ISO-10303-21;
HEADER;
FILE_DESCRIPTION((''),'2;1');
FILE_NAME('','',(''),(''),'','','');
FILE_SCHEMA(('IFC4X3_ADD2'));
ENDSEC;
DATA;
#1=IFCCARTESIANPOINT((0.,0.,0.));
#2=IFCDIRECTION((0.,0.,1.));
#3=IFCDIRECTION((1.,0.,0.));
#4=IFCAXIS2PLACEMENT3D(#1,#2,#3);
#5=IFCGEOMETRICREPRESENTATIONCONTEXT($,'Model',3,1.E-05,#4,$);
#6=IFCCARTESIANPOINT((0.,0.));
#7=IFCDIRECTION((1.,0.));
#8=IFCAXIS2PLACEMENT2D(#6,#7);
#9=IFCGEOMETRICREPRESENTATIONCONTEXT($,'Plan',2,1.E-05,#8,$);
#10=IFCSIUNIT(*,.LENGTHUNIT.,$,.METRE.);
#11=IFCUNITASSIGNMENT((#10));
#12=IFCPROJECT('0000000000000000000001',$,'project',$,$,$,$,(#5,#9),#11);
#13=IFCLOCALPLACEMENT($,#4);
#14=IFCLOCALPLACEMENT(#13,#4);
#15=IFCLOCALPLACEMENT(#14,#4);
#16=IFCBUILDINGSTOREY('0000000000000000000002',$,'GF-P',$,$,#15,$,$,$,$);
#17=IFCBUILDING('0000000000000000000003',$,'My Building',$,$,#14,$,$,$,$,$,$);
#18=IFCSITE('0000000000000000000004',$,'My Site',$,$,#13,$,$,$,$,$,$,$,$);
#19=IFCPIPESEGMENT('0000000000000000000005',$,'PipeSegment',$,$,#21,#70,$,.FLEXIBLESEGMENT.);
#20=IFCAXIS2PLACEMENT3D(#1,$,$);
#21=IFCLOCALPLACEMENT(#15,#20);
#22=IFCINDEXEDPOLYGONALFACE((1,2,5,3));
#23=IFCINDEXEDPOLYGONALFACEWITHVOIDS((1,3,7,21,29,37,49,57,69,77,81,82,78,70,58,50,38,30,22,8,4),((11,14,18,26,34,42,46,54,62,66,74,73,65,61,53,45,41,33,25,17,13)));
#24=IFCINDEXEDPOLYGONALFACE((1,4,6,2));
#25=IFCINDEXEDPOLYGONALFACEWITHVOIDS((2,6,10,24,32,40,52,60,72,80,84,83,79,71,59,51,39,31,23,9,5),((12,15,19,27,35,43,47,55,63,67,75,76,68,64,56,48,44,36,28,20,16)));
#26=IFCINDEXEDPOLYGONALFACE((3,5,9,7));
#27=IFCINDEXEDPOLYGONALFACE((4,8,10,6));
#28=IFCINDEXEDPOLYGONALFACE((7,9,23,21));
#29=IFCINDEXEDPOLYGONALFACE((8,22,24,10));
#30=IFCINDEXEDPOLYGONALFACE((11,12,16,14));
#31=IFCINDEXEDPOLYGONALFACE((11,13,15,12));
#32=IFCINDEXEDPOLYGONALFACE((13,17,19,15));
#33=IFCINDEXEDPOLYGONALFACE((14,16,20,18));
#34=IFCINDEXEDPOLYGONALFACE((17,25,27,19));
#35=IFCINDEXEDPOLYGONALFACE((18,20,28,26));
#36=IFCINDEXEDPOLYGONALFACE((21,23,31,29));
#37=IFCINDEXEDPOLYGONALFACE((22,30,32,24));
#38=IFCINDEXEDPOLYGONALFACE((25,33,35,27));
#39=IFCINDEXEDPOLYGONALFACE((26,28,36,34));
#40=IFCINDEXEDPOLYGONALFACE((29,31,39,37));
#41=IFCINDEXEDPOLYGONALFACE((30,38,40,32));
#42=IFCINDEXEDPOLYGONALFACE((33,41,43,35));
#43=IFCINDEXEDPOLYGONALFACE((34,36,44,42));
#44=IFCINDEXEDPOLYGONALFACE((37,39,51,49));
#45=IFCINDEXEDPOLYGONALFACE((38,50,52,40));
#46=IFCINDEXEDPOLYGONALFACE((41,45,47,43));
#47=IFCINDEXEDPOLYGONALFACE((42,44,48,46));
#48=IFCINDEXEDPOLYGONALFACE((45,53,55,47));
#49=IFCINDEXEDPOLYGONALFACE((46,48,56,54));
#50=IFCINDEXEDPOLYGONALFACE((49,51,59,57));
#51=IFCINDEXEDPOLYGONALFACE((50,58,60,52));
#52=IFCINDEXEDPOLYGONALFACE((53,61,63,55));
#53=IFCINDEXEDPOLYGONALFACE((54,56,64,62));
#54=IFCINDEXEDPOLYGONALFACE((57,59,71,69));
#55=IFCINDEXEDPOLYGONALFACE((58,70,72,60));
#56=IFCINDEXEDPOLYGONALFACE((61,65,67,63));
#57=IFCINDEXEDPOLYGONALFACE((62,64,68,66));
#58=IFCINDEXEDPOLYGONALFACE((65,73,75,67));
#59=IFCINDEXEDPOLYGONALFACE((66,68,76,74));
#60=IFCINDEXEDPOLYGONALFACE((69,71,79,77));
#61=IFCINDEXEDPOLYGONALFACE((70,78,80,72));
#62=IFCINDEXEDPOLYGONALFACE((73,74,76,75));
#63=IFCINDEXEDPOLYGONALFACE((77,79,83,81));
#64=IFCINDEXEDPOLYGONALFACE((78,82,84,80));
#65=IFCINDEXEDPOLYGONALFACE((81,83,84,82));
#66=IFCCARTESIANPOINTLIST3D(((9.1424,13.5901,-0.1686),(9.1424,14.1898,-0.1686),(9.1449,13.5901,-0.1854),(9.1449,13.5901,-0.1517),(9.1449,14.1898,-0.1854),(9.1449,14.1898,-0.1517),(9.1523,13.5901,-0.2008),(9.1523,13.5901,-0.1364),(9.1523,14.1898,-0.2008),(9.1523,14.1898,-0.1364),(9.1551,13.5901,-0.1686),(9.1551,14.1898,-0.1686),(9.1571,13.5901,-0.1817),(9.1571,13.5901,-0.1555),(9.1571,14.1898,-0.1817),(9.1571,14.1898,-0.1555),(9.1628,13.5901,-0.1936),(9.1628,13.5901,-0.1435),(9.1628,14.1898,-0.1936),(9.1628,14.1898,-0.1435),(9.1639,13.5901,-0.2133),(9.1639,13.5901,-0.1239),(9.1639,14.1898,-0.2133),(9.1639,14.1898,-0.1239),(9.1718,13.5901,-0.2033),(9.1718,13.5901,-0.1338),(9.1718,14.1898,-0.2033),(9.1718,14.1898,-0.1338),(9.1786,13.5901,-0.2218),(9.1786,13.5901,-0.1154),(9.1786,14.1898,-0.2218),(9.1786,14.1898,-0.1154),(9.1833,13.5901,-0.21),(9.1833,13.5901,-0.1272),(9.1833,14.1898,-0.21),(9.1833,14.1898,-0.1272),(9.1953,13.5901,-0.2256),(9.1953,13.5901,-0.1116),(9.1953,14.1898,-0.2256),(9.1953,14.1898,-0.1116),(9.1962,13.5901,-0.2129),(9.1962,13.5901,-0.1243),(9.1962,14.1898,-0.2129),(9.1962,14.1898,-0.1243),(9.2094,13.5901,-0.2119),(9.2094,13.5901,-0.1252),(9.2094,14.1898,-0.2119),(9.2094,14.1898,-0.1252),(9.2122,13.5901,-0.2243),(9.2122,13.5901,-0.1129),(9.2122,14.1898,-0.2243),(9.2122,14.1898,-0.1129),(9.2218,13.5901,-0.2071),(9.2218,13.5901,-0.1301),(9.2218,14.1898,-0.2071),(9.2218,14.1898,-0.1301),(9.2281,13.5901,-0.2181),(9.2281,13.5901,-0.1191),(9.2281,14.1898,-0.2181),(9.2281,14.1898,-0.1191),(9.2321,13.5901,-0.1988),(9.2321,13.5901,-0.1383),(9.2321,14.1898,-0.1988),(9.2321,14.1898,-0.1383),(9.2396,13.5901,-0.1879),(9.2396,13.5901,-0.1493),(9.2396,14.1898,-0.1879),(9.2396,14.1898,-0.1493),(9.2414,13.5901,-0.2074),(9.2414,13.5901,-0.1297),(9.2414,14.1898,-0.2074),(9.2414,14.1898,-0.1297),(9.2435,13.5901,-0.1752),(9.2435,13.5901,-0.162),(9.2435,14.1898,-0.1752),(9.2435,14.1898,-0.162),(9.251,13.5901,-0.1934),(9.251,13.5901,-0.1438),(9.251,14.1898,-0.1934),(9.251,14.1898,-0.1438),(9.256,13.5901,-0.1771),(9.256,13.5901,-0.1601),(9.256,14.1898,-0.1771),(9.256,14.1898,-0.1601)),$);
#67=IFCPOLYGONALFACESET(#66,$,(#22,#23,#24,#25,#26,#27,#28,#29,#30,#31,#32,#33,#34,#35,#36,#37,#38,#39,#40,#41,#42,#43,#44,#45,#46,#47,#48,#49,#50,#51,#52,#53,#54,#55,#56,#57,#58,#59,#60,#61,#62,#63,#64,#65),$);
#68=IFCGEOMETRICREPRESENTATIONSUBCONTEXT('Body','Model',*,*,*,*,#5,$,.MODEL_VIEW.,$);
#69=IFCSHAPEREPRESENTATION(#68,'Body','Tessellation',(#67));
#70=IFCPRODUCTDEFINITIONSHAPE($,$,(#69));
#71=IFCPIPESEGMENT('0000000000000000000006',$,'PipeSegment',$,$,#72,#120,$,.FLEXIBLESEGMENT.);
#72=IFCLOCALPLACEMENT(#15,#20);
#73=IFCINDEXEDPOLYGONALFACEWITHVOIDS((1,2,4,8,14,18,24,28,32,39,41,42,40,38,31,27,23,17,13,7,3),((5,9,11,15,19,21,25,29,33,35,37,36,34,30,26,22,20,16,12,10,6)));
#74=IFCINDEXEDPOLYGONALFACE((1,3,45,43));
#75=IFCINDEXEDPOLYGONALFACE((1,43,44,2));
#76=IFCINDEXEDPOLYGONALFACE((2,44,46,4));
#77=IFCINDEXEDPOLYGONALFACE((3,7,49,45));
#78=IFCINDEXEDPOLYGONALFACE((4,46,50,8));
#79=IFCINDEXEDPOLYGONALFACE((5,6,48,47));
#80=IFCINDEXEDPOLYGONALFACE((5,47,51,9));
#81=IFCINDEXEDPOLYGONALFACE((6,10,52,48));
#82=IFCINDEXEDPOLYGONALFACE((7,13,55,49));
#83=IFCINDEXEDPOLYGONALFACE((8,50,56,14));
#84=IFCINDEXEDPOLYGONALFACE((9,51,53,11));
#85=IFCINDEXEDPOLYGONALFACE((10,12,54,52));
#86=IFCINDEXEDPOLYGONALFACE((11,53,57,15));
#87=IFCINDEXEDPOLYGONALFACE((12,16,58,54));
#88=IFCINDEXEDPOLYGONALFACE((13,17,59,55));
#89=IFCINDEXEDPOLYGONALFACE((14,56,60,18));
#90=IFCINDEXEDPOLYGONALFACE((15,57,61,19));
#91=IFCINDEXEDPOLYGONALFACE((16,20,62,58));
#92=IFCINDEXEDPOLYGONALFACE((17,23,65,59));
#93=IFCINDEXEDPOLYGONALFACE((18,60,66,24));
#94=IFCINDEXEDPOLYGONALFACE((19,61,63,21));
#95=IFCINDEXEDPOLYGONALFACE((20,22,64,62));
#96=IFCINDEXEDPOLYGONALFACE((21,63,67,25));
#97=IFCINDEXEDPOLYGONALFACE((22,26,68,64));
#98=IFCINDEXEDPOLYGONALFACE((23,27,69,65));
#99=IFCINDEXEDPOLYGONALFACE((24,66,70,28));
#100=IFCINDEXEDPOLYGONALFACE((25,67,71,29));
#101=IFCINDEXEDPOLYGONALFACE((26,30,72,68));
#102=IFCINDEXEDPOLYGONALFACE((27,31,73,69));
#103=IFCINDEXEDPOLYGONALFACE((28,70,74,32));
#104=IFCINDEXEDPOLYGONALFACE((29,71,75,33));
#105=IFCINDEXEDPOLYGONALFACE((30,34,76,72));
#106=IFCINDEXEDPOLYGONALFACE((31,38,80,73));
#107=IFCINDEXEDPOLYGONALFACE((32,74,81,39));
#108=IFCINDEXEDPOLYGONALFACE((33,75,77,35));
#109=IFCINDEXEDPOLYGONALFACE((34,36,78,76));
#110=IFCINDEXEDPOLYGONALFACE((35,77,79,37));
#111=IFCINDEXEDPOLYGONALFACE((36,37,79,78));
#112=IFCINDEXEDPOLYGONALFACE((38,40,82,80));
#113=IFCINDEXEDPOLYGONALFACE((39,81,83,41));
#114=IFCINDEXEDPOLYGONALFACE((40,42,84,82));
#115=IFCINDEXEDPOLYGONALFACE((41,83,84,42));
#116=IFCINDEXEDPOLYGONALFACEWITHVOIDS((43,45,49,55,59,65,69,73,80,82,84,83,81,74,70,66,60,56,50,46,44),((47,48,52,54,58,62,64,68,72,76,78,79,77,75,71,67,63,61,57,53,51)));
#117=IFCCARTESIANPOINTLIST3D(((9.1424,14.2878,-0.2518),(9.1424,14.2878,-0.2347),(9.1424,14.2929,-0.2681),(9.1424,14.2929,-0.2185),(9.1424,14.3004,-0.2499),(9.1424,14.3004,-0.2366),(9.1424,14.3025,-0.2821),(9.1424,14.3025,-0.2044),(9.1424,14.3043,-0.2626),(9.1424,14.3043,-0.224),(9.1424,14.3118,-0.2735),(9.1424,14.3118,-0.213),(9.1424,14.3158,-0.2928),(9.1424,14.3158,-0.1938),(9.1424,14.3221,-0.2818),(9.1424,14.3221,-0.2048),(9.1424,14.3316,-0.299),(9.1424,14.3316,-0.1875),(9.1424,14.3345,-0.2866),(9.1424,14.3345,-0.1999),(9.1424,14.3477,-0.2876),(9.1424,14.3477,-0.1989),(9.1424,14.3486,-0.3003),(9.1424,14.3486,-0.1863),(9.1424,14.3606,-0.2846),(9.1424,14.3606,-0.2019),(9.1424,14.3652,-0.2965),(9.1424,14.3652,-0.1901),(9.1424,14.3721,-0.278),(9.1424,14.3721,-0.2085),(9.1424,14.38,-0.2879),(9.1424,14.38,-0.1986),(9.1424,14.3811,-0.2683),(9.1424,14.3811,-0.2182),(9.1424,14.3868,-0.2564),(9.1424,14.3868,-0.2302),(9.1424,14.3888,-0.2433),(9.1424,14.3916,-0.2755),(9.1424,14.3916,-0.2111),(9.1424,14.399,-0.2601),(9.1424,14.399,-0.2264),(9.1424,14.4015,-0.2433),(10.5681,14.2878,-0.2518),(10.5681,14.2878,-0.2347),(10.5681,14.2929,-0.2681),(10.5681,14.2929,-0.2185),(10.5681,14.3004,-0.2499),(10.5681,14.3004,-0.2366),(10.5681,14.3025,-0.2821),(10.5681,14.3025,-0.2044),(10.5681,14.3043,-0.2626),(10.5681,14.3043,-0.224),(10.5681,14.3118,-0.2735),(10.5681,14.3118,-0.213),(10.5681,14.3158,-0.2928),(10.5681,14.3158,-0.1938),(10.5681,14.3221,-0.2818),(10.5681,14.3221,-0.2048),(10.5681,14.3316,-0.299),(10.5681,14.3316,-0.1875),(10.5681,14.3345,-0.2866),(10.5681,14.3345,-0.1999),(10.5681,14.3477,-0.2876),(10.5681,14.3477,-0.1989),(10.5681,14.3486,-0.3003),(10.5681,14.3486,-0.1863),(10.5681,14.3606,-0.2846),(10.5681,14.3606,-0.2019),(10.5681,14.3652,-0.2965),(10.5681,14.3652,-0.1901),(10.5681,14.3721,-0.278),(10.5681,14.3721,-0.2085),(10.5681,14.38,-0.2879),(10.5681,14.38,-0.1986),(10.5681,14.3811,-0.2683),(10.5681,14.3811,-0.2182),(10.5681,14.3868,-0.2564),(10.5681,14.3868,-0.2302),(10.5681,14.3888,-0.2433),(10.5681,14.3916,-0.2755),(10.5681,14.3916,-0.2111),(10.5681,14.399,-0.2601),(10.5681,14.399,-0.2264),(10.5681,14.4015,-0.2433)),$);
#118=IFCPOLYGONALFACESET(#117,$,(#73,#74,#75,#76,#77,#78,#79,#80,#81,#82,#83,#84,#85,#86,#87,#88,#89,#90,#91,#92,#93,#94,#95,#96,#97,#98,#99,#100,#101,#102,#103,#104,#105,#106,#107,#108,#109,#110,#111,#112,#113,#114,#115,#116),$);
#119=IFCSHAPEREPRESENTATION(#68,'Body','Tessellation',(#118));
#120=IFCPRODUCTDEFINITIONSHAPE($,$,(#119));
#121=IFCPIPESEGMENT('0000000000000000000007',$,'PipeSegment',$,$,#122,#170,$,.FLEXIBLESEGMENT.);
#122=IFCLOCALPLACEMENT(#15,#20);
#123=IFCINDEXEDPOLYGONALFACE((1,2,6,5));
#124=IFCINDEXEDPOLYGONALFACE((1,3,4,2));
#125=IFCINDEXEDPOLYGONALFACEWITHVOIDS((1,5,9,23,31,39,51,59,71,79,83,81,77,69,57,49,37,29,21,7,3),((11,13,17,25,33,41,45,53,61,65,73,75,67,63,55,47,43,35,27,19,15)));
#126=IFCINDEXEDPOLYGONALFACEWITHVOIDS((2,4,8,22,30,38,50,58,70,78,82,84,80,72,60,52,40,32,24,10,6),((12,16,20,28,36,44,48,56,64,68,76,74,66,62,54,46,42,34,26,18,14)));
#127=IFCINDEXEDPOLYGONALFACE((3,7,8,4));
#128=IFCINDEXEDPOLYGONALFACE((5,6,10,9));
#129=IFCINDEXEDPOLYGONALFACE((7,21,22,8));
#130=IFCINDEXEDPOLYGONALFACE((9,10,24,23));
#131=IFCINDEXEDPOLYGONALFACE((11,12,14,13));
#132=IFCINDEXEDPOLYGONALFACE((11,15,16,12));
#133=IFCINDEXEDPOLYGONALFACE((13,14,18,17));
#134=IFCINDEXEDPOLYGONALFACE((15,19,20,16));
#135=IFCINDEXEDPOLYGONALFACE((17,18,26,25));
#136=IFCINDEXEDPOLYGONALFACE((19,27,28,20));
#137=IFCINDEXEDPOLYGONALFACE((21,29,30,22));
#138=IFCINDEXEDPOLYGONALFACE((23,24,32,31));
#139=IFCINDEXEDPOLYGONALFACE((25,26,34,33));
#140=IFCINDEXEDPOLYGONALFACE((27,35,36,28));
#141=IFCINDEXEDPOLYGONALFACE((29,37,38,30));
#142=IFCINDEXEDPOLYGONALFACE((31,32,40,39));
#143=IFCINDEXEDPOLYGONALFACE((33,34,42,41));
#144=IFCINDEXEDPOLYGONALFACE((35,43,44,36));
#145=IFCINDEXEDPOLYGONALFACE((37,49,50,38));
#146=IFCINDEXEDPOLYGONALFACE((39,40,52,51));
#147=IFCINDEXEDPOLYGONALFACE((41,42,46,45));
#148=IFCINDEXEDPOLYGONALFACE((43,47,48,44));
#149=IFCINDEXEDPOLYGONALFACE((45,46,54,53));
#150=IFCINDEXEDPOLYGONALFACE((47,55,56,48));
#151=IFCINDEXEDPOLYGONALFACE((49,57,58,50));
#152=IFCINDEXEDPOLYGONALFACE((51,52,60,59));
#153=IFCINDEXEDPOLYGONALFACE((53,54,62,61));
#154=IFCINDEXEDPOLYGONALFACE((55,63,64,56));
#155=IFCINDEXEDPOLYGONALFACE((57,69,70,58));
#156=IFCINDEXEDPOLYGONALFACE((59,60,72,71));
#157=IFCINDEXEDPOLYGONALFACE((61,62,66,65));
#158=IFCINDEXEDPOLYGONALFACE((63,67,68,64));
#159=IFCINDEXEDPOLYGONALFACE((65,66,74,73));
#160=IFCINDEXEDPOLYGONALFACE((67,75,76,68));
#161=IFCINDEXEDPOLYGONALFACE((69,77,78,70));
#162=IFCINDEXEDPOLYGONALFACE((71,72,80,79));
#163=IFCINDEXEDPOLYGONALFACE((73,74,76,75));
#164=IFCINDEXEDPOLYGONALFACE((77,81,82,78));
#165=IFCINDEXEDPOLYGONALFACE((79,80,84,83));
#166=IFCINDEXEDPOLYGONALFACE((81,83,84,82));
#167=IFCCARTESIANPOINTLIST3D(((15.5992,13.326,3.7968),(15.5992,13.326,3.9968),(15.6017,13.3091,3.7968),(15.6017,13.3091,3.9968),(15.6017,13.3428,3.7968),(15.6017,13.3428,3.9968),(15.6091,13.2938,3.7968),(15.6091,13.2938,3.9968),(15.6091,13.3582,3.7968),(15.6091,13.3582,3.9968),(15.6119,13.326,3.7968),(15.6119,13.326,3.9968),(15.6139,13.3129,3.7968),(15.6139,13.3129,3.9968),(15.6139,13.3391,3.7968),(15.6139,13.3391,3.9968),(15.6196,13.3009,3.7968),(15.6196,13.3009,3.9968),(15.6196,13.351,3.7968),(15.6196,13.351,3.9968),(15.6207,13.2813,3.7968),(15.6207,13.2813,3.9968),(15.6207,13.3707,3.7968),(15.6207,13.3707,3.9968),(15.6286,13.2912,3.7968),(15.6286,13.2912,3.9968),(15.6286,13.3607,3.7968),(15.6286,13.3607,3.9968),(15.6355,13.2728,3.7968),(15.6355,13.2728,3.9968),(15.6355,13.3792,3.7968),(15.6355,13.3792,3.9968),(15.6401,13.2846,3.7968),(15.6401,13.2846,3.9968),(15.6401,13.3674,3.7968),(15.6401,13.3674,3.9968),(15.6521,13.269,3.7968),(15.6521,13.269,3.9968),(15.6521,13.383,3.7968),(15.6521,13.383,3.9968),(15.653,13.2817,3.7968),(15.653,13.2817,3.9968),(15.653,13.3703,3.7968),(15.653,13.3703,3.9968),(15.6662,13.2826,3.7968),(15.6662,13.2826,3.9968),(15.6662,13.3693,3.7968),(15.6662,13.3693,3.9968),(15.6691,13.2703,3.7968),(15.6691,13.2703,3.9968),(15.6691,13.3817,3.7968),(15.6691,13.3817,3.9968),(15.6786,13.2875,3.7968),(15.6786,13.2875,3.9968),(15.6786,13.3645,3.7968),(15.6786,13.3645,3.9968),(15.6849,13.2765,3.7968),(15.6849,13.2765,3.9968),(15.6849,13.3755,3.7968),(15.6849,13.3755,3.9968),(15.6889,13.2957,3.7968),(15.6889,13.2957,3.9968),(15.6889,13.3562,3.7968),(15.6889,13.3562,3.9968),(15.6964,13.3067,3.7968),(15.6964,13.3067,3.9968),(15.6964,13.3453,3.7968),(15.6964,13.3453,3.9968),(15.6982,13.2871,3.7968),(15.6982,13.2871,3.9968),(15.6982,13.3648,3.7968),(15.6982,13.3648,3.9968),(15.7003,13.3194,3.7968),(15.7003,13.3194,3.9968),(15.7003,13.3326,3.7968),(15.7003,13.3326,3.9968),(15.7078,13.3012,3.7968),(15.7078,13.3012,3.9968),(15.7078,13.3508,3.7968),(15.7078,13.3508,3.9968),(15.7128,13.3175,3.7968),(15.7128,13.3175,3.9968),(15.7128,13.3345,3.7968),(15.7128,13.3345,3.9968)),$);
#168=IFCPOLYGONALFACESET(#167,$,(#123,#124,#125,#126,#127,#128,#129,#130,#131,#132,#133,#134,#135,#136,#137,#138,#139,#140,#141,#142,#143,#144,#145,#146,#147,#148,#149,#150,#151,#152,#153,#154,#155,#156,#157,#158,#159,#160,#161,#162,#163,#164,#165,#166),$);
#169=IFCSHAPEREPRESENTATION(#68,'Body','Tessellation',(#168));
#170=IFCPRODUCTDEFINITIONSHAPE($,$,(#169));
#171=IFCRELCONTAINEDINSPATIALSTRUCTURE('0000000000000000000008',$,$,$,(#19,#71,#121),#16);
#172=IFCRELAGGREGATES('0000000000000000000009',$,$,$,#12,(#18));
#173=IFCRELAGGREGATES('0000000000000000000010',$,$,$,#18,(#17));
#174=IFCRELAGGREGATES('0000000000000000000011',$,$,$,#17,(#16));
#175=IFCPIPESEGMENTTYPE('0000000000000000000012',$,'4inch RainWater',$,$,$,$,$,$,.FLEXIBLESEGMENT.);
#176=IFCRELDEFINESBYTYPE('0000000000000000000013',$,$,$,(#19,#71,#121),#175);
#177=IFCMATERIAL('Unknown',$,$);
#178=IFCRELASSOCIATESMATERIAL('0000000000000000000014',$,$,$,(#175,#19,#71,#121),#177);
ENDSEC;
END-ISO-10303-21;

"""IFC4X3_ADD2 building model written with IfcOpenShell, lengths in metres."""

from ifc_helpers import new_model, si_unit, frame, origin_with_axes, origin_2d_with_axis, place, context, subcontext, project, spatial, hollow_circle, extrude, material, material_profile, profile_set, profile_usage, type_object, element, save


model = new_model("IFC4X3_ADD2")

# Units and contexts
model_context = context("Model", 3, precision=1e-05, world=origin_with_axes())
plan_context = context("Plan", 2, precision=1e-05, world=origin_2d_with_axis())
body_context = subcontext(model_context, "Body", "Model", "MODEL_VIEW")
ifc_project = project(units=[si_unit("LENGTHUNIT", "METRE")], contexts=[model_context, plan_context])

# Site, building, storey
site_placement = place(None, origin_with_axes())
site = spatial("IfcSite", under=ifc_project, at=site_placement, Name="My Site")
building_placement = place(site_placement, origin_with_axes())
building = spatial("IfcBuilding", under=site, at=building_placement, Name="My Building")
storey_placement = place(building_placement, origin_with_axes())
storey = spatial("IfcBuildingStorey", under=building, at=storey_placement, Name="GF-P")

# Shared definitions
ifc_material_1 = material(Name="Unknown")

# Pipe segments
ifc_material_profile_1 = material_profile(ifc_material_1, hollow_circle(Radius=0.0571, WallThickness=0.0127))
ifc_profile_set_1 = profile_set([ifc_material_profile_1], Name="rainwater")
pipe_segment_type_1 = type_object("IfcPipeSegmentType", Name="4inch RainWater", PredefinedType="FLEXIBLESEGMENT", material=ifc_profile_set_1)
ifc_profile_usage_1 = profile_usage(ifc_profile_set_1)
pipe_segment_1_placement = place(storey_placement, frame((9.1995, 13.5901, -0.1686), z_axis=(0.0, 1.0, 0.0), x_axis=(-1.0, 0.0, 0.0)))
element("IfcPipeSegment", 1, at=pipe_segment_1_placement, inside=storey, type_object=pipe_segment_type_1, material=ifc_profile_usage_1, Name="PipeSegment", PredefinedType="FLEXIBLESEGMENT", context=body_context, shape_type="SweptSolid", body=[
    extrude(hollow_circle(Radius=0.0571, WallThickness=0.0127), origin_with_axes(), (0.0, 0.0, 1.0), 0.5998),
])
ifc_profile_usage_2 = profile_usage(ifc_profile_set_1)
pipe_segment_2_placement = place(storey_placement, frame((9.1424, 14.3444, -0.2433), z_axis=(1.0, 0.0, 0.0), x_axis=(0.0, 1.0, 0.0)))
element("IfcPipeSegment", 2, at=pipe_segment_2_placement, inside=storey, type_object=pipe_segment_type_1, material=ifc_profile_usage_2, Name="PipeSegment", PredefinedType="FLEXIBLESEGMENT", context=body_context, shape_type="SweptSolid", body=[
    extrude(hollow_circle(Radius=0.0571, WallThickness=0.0127), origin_with_axes(), (0.0, 0.0, 1.0), 1.4257),
])
ifc_profile_usage_3 = profile_usage(ifc_profile_set_1)
pipe_segment_3_placement = place(storey_placement, frame((15.6563, 13.326, 3.7968), z_axis=(0.0, 0.0, 1.0), x_axis=(-1.0, 0.0, 0.0)))
element("IfcPipeSegment", 3, at=pipe_segment_3_placement, inside=storey, type_object=pipe_segment_type_1, material=ifc_profile_usage_3, Name="PipeSegment", PredefinedType="FLEXIBLESEGMENT", context=body_context, shape_type="SweptSolid", body=[
    extrude(hollow_circle(Radius=0.0571, WallThickness=0.0127), origin_with_axes(), (0.0, 0.0, 1.0), 0.2),
])

save(model, "model.ifc")
